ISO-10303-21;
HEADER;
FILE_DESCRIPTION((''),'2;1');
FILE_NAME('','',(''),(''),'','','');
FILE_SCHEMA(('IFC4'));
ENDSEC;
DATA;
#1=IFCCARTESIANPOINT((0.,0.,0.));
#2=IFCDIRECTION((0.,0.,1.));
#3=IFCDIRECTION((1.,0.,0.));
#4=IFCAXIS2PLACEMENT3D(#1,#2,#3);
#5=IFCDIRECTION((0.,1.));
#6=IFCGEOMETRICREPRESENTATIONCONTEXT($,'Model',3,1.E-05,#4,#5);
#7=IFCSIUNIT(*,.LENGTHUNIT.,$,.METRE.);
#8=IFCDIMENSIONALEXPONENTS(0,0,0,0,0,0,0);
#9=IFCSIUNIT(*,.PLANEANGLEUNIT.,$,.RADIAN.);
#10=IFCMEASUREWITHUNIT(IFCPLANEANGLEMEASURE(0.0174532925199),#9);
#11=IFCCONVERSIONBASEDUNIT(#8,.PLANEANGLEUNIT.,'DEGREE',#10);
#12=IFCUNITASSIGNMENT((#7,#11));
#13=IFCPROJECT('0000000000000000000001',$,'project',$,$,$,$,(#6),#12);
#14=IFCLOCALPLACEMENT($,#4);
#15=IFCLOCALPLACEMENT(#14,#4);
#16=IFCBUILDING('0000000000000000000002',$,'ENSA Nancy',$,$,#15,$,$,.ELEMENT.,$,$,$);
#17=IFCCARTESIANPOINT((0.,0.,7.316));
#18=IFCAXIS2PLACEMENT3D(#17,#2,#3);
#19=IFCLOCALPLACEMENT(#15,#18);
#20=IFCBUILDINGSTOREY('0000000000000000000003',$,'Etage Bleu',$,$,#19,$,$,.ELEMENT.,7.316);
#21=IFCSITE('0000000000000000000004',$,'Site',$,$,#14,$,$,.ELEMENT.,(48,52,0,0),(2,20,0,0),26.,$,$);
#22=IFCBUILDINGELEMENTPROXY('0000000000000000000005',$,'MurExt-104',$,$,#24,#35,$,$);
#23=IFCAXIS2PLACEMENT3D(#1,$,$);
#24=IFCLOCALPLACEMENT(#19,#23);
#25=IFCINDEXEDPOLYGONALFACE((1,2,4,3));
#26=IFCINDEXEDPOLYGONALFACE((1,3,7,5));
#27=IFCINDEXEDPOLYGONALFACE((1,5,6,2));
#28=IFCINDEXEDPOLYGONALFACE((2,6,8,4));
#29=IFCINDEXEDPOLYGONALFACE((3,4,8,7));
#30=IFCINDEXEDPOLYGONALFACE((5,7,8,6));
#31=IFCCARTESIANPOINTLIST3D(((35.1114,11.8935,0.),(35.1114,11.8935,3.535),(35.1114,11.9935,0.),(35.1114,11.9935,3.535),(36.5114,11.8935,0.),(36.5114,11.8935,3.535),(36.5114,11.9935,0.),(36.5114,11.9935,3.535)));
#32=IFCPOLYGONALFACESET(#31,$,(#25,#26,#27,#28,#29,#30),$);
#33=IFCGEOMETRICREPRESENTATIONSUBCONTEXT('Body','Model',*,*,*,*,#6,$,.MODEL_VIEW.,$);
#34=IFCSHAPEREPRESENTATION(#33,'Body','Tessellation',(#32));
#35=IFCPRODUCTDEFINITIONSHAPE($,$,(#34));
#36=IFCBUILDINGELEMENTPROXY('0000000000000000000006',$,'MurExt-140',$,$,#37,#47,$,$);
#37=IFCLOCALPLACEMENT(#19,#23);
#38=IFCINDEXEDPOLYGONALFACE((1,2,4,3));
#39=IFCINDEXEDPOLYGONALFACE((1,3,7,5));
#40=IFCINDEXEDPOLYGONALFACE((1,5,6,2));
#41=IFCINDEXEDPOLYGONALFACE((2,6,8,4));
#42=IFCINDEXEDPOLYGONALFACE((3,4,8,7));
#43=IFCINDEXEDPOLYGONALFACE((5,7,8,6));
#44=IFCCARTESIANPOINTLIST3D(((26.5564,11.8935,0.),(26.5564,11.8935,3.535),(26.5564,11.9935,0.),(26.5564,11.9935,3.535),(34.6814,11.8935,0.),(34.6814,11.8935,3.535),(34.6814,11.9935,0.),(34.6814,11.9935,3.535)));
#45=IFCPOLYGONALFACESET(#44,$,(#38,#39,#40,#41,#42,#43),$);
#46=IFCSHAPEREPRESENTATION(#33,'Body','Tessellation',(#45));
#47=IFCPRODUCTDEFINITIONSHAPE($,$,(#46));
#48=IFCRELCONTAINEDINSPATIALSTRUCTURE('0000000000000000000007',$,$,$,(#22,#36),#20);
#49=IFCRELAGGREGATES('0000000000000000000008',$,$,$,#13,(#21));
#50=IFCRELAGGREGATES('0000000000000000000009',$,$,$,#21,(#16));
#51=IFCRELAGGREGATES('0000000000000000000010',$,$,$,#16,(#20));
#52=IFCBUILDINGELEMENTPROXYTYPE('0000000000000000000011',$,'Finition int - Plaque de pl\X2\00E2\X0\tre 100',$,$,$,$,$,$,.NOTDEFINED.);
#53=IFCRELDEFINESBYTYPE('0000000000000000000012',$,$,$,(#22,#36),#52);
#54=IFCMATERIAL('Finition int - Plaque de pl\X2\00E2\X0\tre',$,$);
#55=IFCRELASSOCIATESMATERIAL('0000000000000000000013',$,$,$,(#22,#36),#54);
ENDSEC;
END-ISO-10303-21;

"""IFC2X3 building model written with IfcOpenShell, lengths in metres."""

from ifc_helpers import new_model, entity, si_unit, converted_unit, direction, frame, origin_with_axes, place, context, subcontext, project, spatial, polyline, outline, extrude, material, type_object, element, save


model = new_model("IFC2X3")

# Units and contexts
model_context = context("Model", 3, precision=1e-05, world=origin_with_axes(), true_north=direction((0.0, 1.0)))
body_context = subcontext(model_context, "Body", "Model", "MODEL_VIEW")
ifc_project = project(units=[si_unit("LENGTHUNIT", "METRE"), converted_unit("PLANEANGLEUNIT", "DEGREE", entity("IfcPlaneAngleMeasure", 0.0174532925199), si_unit("PLANEANGLEUNIT", "RADIAN"), dimensions=[0, 0, 0, 0, 0, 0, 0])], contexts=[model_context])

# Site, building, storey
site_placement = place(None, origin_with_axes())
site = spatial("IfcSite", under=ifc_project, at=site_placement, Name="Site", CompositionType="ELEMENT", RefLatitude=(48, 52, 0, 0), RefLongitude=(2, 20, 0, 0), RefElevation=26.0)
building_placement = place(site_placement, origin_with_axes())
building = spatial("IfcBuilding", under=site, at=building_placement, Name="ENSA Nancy", CompositionType="ELEMENT")
storey_placement = place(building_placement, frame((0.0, 0.0, 7.316), z_axis=(0.0, 0.0, 1.0), x_axis=(1.0, 0.0, 0.0)))
storey = spatial("IfcBuildingStorey", under=building, at=storey_placement, Name="Etage Bleu", CompositionType="ELEMENT", Elevation=7.316)

# Building element proxies
ifc_material_1 = material(Name="Finition int - Plaque de plâtre")
building_element_proxy_type_1 = type_object("IfcBuildingElementProxyType", Name="Finition int - Plaque de plâtre 100", PredefinedType="NOTDEFINED")
proxy_1_placement = place(storey_placement, frame((35.1114, 11.8935, 0.0), z_axis=(0.0, 0.0, 1.0), x_axis=(1.0, 0.0, 0.0)))
element("IfcBuildingElementProxy", 1, at=proxy_1_placement, inside=storey, type_object=building_element_proxy_type_1, material=ifc_material_1, Name="MurExt-104", context=body_context, shape_type="SweptSolid", body=[
    extrude(outline(polyline([(0.0, 0.0), (1.4, 0.0), (1.4, 0.1), (0.0, 0.1), (0.0, 0.0)])), origin_with_axes(), (0.0, 0.0, 1.0), 3.535),
])
proxy_2_placement = place(storey_placement, frame((26.5564, 11.8935, 0.0), z_axis=(0.0, 0.0, 1.0), x_axis=(1.0, 0.0, 0.0)))
element("IfcBuildingElementProxy", 2, at=proxy_2_placement, inside=storey, type_object=building_element_proxy_type_1, material=ifc_material_1, Name="MurExt-140", context=body_context, shape_type="SweptSolid", body=[
    extrude(outline(polyline([(0.0, 0.0), (8.125, 0.0), (8.125, 0.1), (0.0, 0.1), (0.0, 0.0)])), origin_with_axes(), (0.0, 0.0, 1.0), 3.535),
])

save(model, "model.ifc")
